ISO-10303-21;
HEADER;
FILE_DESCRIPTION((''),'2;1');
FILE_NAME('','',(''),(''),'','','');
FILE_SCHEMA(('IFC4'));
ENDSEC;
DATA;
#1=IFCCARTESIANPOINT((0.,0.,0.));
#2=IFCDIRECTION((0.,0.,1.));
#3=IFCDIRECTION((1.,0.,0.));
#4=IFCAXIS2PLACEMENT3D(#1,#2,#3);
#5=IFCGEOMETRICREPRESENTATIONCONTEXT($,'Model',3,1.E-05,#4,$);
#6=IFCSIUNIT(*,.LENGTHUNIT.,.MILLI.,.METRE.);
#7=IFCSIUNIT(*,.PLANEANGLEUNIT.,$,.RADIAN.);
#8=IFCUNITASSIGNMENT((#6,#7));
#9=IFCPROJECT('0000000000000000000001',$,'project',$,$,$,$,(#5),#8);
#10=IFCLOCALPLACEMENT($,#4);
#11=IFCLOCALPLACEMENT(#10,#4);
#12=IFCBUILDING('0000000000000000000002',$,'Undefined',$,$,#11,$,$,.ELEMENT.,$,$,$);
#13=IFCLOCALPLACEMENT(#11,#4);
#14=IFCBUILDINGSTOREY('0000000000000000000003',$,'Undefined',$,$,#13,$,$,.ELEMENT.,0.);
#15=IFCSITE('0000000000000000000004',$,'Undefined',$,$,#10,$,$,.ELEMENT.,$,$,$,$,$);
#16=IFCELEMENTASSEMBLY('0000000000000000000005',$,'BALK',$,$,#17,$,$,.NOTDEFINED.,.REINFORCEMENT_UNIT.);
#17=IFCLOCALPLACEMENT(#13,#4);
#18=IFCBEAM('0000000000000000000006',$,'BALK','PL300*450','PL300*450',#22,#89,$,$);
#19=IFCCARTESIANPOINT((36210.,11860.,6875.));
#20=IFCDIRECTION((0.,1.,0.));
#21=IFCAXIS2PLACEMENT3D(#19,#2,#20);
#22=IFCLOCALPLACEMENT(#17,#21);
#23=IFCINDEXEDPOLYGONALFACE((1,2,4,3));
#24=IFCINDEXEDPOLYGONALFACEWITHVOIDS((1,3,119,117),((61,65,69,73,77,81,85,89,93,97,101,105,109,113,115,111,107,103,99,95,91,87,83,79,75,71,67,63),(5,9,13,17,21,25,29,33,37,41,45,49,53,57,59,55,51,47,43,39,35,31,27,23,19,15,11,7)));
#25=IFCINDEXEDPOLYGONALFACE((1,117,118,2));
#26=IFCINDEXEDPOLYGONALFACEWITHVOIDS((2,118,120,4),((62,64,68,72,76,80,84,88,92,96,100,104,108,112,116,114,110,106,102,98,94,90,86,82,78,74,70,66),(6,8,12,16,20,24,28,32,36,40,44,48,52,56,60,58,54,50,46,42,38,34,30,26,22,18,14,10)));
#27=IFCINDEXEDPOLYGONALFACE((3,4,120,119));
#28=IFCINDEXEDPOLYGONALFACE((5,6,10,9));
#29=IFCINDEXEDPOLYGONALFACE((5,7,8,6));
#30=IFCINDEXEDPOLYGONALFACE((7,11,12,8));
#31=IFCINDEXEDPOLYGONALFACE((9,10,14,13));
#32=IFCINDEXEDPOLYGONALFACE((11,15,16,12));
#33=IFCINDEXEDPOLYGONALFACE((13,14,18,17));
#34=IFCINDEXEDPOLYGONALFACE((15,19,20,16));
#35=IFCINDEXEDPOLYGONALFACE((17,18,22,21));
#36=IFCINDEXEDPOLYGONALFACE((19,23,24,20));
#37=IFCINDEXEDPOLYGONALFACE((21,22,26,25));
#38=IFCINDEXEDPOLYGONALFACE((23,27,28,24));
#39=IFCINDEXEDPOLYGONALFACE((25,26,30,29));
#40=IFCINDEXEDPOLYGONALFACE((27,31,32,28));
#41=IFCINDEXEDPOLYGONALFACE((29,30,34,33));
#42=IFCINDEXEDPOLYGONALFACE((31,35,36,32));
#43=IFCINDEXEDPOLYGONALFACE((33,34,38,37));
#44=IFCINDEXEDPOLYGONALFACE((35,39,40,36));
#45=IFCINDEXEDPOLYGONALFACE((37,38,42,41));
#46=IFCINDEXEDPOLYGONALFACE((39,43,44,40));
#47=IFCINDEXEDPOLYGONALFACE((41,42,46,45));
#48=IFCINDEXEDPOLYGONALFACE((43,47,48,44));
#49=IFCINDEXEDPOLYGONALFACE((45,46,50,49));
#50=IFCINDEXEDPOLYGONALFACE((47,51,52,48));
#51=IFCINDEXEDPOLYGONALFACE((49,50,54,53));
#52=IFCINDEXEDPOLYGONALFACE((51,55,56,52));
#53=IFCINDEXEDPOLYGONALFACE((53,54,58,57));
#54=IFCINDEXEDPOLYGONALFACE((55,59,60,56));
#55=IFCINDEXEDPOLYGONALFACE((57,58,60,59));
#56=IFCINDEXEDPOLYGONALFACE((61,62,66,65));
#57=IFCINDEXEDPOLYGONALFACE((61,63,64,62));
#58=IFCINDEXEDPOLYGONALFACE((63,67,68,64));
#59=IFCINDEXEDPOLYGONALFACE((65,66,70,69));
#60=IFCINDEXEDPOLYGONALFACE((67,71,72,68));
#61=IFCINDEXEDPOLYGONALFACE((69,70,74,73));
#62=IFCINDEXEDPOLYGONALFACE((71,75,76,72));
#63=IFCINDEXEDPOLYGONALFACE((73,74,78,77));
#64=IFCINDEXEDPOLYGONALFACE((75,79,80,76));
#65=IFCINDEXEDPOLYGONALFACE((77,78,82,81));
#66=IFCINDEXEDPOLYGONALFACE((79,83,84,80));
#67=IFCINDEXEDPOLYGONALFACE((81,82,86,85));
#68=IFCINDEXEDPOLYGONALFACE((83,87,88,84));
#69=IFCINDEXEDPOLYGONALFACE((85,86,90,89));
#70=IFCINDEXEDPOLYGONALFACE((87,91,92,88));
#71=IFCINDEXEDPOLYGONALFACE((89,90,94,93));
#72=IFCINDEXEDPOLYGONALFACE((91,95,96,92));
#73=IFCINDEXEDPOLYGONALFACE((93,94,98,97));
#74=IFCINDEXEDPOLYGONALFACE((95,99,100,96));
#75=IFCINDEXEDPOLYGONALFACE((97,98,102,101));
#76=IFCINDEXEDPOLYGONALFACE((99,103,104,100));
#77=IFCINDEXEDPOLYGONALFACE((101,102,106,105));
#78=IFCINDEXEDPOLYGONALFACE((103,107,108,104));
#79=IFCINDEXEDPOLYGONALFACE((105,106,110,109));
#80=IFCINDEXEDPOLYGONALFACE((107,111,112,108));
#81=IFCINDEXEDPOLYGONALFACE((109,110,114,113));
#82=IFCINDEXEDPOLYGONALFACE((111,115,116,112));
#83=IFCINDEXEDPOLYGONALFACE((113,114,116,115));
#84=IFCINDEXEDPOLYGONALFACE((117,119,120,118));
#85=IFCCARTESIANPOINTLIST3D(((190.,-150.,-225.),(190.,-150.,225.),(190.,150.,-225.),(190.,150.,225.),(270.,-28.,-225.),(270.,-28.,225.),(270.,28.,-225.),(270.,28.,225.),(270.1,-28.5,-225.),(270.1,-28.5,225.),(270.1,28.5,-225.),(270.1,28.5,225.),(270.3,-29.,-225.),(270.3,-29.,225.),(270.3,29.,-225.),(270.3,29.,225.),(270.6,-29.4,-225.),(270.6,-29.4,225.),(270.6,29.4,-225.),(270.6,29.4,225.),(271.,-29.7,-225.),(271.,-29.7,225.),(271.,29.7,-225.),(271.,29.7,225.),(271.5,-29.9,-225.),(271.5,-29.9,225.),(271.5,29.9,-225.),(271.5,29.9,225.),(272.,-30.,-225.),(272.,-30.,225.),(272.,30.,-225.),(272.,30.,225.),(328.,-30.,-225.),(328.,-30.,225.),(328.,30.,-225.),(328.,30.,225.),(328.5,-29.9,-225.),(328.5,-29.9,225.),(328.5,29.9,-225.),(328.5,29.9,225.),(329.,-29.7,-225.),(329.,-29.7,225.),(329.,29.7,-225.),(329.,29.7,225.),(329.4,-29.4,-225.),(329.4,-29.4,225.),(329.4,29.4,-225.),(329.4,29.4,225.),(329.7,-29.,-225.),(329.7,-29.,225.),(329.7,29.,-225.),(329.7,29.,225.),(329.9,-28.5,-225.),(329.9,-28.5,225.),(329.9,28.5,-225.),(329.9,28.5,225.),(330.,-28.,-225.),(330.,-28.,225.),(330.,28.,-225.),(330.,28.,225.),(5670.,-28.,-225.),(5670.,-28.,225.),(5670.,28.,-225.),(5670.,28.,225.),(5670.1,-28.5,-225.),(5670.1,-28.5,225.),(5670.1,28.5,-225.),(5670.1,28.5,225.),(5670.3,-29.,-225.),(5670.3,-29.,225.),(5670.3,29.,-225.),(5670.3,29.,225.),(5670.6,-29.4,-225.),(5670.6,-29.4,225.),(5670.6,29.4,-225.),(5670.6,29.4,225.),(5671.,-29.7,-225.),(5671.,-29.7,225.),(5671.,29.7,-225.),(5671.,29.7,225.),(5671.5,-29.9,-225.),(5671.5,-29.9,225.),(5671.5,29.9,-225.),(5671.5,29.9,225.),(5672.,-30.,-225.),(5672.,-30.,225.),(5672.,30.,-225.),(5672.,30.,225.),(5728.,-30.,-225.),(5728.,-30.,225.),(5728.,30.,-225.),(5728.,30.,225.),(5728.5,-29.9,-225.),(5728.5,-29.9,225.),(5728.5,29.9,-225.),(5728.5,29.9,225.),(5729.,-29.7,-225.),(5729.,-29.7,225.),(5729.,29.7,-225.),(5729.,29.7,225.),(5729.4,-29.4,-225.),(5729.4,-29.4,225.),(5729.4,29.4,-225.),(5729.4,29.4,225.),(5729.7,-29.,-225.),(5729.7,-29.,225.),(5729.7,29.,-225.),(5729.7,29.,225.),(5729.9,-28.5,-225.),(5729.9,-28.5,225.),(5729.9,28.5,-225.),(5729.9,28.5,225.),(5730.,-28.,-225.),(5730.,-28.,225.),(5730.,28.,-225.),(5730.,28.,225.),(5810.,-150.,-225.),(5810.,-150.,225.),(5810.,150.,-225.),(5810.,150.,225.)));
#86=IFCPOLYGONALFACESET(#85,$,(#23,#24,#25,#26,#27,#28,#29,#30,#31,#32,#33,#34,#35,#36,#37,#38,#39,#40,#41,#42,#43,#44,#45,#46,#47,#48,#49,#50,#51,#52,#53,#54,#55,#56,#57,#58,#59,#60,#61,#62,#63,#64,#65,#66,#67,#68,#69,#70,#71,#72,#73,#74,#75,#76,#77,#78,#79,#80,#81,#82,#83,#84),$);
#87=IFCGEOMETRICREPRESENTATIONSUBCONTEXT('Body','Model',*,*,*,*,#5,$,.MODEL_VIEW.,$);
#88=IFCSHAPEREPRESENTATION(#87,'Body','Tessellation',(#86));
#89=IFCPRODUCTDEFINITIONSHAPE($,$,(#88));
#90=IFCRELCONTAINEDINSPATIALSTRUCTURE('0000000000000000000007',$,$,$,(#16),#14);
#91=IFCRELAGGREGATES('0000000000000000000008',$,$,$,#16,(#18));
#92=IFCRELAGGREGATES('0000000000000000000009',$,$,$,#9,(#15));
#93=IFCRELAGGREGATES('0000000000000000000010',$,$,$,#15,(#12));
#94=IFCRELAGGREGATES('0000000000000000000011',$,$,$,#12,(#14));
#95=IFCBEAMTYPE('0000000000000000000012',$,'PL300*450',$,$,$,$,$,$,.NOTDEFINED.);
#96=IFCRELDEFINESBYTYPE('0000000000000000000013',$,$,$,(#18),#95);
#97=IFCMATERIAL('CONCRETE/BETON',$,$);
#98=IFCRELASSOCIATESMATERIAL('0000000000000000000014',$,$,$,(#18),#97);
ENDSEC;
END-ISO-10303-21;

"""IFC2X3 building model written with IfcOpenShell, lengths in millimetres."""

from ifc_helpers import new_model, si_unit, frame, frame_2d, origin_with_axes, place, context, subcontext, project, spatial, rectangle, rounded_rectangle, extrude, boolean, halfspace, material, type_object, element, aggregate, save


model = new_model("IFC2X3")

# Units and contexts
model_context = context("Model", 3, precision=1e-05, world=origin_with_axes())
body_context = subcontext(model_context, "Body", "Model", "MODEL_VIEW")
ifc_project = project(units=[si_unit("LENGTHUNIT", "METRE", prefix="MILLI"), si_unit("PLANEANGLEUNIT", "RADIAN")], contexts=[model_context])

# Site, building, storey
site_placement = place(None, origin_with_axes())
site = spatial("IfcSite", under=ifc_project, at=site_placement, Name="Undefined", CompositionType="ELEMENT")
building_placement = place(site_placement, origin_with_axes())
building = spatial("IfcBuilding", under=site, at=building_placement, Name="Undefined", CompositionType="ELEMENT")
storey_placement = place(building_placement, origin_with_axes())
storey = spatial("IfcBuildingStorey", under=building, at=storey_placement, Name="Undefined", CompositionType="ELEMENT", Elevation=0.0)

# Shared definitions
ifc_material_1 = material(Name="CONCRETE/BETON")

# Element assembly
assembly_1_placement = place(storey_placement, origin_with_axes())
assembly_1 = element("IfcElementAssembly", 1, at=assembly_1_placement, inside=storey, Name="BALK", AssemblyPlace="NOTDEFINED", PredefinedType="REINFORCEMENT_UNIT")

# Beam
beam_type_1 = type_object("IfcBeamType", Name="PL300*450", PredefinedType="NOTDEFINED")
beam_1_placement = place(assembly_1_placement, frame((36210.0, 11860.0, 6875.0), z_axis=(0.0, 0.0, 1.0), x_axis=(0.0, 1.0, 0.0)))
beam_1 = element("IfcBeam", 2, at=beam_1_placement, type_object=beam_type_1, material=ifc_material_1, Name="BALK", Description="PL300*450", ObjectType="PL300*450", context=body_context, shape_type="CSG", body=[
    boolean("DIFFERENCE", boolean("DIFFERENCE", boolean("DIFFERENCE", boolean("DIFFERENCE", extrude(rectangle(XDim=300.0, YDim=450.0, at=frame_2d((0.0, 0.0), x_axis=(1.0, 0.0))), frame((5810.0, 0.0, 0.0), z_axis=(-1.0, 0.0, 0.0), x_axis=(0.0, -1.0, 0.0)), (0.0, 0.0, 1.0), 5620.0), extrude(rounded_rectangle(XDim=60.0, YDim=60.0, RoundingRadius=2.0, at=frame_2d((0.0, 0.0), x_axis=(1.0, 0.0))), frame((300.0, 0.0, 275.0), z_axis=(0.0, 0.0, -1.0), x_axis=(1.0, 0.0, 0.0)), (0.0, 0.0, 1.0), 650.5)), extrude(rounded_rectangle(XDim=60.0, YDim=60.0, RoundingRadius=2.0, at=frame_2d((0.0, 0.0), x_axis=(1.0, 0.0))), frame((5700.0, 0.0, 275.0), z_axis=(0.0, 0.0, -1.0), x_axis=(-1.0, 0.0, 0.0)), (0.0, 0.0, 1.0), 650.5)), halfspace(frame((5810.0, 0.0, 10.0), z_axis=(1.0, 0.0, 0.0), x_axis=(0.0, 1.0, 0.0)), False)), halfspace(frame((190.0, 0.0, 10.0), z_axis=(-1.0, 0.0, 0.0), x_axis=(0.0, -1.0, 0.0)), False)),
])
aggregate(assembly_1, [beam_1])

save(model, "model.ifc")
